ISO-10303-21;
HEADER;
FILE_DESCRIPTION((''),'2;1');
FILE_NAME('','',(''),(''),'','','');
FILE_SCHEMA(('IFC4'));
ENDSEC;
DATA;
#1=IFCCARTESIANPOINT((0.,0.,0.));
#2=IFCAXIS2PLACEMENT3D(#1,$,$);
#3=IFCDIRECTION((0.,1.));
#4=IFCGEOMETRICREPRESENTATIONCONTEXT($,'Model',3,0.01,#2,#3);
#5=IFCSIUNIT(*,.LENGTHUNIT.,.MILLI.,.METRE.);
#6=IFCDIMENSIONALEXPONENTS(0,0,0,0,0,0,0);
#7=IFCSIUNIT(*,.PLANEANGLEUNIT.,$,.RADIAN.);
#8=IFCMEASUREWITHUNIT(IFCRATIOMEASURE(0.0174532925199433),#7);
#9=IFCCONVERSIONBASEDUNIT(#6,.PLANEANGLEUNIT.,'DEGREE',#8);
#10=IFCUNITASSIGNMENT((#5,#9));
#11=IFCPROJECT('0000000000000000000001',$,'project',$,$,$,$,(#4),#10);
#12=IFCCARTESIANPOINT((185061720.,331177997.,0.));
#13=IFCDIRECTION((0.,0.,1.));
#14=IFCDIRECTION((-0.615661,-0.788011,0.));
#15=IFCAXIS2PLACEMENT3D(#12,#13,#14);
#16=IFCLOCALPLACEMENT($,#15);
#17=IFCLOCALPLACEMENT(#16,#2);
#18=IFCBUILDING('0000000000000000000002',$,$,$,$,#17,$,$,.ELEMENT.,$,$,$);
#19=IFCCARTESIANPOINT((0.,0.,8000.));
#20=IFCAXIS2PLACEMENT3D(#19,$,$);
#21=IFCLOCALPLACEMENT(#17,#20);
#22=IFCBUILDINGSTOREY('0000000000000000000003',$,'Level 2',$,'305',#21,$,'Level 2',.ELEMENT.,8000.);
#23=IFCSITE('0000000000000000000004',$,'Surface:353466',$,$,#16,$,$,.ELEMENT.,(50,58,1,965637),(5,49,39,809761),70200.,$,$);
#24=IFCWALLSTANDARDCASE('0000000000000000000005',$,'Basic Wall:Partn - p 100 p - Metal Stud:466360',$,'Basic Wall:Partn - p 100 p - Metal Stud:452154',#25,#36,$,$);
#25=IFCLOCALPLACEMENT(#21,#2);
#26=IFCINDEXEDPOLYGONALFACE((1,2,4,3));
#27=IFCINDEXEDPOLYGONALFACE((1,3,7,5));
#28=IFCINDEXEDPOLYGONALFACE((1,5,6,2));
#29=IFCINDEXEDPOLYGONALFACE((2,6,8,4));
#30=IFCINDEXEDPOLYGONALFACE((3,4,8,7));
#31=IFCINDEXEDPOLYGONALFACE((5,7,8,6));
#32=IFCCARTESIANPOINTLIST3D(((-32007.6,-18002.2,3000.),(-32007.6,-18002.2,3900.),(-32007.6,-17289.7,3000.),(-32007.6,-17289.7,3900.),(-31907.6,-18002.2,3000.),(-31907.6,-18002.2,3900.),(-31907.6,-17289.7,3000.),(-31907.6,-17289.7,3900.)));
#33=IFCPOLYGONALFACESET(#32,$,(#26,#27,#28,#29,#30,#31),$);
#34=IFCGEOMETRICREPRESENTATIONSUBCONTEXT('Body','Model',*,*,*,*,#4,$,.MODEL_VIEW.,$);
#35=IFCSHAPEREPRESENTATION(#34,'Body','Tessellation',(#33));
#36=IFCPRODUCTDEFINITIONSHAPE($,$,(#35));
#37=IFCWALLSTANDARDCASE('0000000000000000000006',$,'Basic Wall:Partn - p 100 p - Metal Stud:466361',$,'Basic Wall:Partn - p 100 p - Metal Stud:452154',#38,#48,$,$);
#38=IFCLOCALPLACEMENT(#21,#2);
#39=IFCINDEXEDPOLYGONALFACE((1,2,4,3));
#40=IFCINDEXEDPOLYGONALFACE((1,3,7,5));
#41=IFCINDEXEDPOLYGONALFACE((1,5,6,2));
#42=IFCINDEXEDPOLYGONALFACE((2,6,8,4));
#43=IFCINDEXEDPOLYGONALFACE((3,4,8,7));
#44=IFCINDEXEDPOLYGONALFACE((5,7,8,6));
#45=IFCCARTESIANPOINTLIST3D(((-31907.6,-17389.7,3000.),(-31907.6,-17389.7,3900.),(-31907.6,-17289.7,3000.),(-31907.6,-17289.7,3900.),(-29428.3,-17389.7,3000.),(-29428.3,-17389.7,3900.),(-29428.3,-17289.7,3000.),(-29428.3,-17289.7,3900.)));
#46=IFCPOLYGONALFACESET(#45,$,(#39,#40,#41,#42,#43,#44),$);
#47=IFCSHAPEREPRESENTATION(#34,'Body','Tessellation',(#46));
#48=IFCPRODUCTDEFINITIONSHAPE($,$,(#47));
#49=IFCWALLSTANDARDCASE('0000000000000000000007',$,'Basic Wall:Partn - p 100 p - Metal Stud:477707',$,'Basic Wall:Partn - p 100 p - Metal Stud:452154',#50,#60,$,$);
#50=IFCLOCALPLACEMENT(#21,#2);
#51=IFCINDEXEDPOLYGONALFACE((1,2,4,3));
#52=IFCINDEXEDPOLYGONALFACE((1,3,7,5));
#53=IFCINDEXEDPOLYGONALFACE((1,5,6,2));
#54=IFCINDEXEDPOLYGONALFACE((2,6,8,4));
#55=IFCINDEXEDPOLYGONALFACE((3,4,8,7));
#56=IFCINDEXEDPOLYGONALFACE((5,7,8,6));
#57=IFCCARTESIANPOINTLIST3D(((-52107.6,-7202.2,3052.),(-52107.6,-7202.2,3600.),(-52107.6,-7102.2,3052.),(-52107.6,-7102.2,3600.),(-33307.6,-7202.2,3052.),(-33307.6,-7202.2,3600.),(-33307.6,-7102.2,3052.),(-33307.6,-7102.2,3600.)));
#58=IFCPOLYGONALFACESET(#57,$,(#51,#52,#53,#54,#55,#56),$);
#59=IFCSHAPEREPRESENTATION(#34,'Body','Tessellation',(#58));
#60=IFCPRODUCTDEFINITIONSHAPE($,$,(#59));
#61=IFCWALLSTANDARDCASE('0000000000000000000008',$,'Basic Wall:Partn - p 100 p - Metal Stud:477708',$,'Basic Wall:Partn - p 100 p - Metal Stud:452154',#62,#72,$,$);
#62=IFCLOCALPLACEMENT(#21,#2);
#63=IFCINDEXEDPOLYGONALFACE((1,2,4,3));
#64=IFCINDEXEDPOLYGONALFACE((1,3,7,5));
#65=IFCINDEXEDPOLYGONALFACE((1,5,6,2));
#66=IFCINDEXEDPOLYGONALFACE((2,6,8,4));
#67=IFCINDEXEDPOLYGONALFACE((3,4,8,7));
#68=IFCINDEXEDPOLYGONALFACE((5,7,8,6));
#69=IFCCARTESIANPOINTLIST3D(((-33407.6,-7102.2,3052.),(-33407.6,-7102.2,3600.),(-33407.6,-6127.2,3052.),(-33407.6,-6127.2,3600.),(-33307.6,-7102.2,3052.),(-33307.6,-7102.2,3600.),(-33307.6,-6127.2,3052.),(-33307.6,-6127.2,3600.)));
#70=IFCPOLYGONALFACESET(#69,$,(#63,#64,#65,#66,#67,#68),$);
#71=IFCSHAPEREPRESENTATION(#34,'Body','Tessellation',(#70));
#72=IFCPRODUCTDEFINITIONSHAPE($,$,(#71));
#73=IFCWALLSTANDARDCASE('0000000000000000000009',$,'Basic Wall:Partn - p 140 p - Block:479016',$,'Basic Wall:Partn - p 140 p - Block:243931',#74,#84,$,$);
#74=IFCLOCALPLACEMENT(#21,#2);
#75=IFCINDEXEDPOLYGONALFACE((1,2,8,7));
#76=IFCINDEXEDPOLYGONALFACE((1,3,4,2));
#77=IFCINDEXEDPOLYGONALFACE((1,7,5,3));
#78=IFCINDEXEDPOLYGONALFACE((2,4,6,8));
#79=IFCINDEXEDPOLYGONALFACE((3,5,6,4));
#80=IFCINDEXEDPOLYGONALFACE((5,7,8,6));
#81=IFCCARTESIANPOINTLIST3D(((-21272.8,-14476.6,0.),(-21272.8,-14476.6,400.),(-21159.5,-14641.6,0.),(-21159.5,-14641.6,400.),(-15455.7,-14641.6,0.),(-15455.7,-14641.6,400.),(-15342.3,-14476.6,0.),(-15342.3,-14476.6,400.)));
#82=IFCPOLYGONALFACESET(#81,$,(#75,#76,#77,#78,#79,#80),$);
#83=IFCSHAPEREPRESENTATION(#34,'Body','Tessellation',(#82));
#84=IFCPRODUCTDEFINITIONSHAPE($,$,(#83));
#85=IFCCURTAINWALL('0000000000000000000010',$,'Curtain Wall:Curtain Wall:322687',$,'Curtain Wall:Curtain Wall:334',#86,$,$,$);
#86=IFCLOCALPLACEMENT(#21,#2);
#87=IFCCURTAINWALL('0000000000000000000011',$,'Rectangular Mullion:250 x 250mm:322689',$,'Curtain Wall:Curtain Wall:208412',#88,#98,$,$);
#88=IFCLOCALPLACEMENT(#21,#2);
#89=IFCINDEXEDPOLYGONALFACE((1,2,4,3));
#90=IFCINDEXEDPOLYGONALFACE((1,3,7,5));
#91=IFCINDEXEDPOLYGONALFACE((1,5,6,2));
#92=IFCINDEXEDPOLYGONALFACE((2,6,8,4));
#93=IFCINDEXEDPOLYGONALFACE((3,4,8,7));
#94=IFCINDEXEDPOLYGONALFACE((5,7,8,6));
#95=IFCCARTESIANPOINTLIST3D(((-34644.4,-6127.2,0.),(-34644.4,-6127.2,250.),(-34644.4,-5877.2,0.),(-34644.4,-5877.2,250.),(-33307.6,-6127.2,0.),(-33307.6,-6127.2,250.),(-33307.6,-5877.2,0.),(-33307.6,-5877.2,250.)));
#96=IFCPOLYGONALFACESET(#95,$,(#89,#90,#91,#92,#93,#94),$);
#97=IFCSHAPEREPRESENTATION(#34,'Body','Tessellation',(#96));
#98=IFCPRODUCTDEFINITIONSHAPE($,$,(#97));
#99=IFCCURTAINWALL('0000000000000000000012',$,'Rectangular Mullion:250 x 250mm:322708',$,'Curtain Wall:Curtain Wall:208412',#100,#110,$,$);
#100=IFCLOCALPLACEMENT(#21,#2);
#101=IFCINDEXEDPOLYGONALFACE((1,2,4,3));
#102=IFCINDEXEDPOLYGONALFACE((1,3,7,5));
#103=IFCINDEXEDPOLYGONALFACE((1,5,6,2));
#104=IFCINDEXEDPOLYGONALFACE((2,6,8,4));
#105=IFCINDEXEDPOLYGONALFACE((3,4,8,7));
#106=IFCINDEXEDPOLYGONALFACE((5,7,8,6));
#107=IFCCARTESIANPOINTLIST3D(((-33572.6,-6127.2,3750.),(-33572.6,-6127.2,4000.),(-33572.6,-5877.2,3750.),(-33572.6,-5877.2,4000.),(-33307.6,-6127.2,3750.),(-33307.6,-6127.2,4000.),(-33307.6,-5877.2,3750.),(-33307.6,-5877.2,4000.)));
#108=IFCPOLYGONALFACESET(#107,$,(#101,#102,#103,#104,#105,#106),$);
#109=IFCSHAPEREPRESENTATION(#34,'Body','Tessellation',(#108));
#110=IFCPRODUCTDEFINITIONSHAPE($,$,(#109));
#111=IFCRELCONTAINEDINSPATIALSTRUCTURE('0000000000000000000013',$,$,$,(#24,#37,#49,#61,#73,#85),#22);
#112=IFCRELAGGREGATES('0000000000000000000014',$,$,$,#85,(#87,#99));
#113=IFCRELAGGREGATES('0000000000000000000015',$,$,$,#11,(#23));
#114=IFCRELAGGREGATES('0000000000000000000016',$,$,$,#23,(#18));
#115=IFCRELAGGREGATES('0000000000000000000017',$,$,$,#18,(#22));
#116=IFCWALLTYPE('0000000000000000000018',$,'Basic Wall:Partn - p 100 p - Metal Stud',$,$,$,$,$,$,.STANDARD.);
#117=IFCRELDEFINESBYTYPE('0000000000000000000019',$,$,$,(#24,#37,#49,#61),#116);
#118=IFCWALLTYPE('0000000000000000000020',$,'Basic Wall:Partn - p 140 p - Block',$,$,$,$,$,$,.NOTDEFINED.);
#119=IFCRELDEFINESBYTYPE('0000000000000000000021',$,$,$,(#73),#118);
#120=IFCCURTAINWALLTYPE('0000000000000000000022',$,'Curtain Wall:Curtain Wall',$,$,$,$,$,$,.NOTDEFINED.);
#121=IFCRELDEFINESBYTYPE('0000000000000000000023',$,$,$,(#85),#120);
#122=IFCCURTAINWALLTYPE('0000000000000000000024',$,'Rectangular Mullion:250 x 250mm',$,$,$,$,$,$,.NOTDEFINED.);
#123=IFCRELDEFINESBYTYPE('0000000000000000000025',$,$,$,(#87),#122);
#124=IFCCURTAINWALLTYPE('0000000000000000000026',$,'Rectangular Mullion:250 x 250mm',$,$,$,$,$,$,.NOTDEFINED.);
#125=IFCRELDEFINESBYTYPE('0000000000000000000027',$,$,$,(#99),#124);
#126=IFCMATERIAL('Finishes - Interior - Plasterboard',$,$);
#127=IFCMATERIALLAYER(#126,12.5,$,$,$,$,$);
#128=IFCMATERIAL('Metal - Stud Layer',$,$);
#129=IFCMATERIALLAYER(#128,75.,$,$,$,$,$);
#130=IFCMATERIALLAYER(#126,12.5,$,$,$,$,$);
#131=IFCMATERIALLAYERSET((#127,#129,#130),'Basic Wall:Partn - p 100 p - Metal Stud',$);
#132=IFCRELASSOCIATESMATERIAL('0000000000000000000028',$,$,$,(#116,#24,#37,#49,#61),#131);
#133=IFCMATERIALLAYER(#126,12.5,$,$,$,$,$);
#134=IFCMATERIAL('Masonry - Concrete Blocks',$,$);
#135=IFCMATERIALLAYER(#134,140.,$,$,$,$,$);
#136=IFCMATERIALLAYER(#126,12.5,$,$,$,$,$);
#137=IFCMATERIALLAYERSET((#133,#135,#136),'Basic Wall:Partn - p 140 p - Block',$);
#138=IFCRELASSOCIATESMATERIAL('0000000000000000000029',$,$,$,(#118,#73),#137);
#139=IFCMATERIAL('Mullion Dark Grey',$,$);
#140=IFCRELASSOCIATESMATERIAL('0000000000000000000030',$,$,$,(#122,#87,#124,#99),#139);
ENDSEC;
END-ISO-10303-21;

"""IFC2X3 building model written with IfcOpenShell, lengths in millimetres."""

from ifc_helpers import new_model, entity, si_unit, converted_unit, direction, frame, frame_2d, origin, origin_2d_with_axis, place, context, subcontext, project, spatial, polyline, rectangle, outline, extrude, clip, halfspace, bounded_halfspace, source, transform, mapped, material, layer, layer_set, layer_usage, type_object, type_shapes, element, aggregate, save


model = new_model("IFC2X3")

# Units and contexts
model_context = context("Model", 3, precision=0.01, world=origin(), true_north=direction((0.0, 1.0)))
body_context = subcontext(model_context, "Body", "Model", "MODEL_VIEW")
ifc_project = project(units=[si_unit("LENGTHUNIT", "METRE", prefix="MILLI"), converted_unit("PLANEANGLEUNIT", "DEGREE", entity("IfcRatioMeasure", 0.0174532925199433), si_unit("PLANEANGLEUNIT", "RADIAN"), dimensions=[0, 0, 0, 0, 0, 0, 0])], contexts=[model_context])

# Site, building, storey
site_placement = place(None, frame((185061720.0, 331177997.0, 0.0), z_axis=(0.0, 0.0, 1.0), x_axis=(-0.615661, -0.788011, 0.0)))
site = spatial("IfcSite", under=ifc_project, at=site_placement, Name="Surface:353466", CompositionType="ELEMENT", RefLatitude=(50, 58, 1, 965637), RefLongitude=(5, 49, 39, 809761), RefElevation=70200.0)
building_placement = place(site_placement, origin())
building = spatial("IfcBuilding", under=site, at=building_placement, CompositionType="ELEMENT")
storey_placement = place(building_placement, frame((0.0, 0.0, 8000.0)))
storey = spatial("IfcBuildingStorey", under=building, at=storey_placement, Name="Level 2", ObjectType="305", LongName="Level 2", CompositionType="ELEMENT", Elevation=8000.0)

# Shared definitions
ifc_material_1 = material(Name="Masonry - Concrete Blocks")
ifc_material_2 = material(Name="Finishes - Interior - Plasterboard")

# Walls
ifc_layer_1 = layer(ifc_material_2, 12.5)
ifc_material_3 = material(Name="Metal - Stud Layer")
ifc_layer_2 = layer(ifc_material_3, 75.0)
ifc_layer_3 = layer(ifc_material_2, 12.5)
ifc_layer_set_1 = layer_set([ifc_layer_1, ifc_layer_2, ifc_layer_3], Name="Basic Wall:Partn - p 100 p - Metal Stud")
wall_type_1 = type_object("IfcWallType", Name="Basic Wall:Partn - p 100 p - Metal Stud", PredefinedType="STANDARD", material=ifc_layer_set_1)
ifc_layer_usage_1 = layer_usage(ifc_layer_set_1, "AXIS2", "NEGATIVE", 50.0)
wall_1_placement = place(storey_placement, frame((-31957.6, -17289.7, 3000.0), z_axis=(0.0, 0.0, 1.0), x_axis=(0.0, -1.0, 0.0)))
element("IfcWallStandardCase", 1, at=wall_1_placement, inside=storey, type_object=wall_type_1, material=ifc_layer_usage_1, Name="Basic Wall:Partn - p 100 p - Metal Stud:466360", ObjectType="Basic Wall:Partn - p 100 p - Metal Stud:452154", context=body_context, shape_type="SweptSolid", body=[
    extrude(rectangle(XDim=712.5, YDim=100.0, at=frame_2d((356.2, 0.0), x_axis=(-1.0, 0.0))), origin(), (0.0, 0.0, 1.0), 900.0),
])
ifc_layer_usage_2 = layer_usage(ifc_layer_set_1, "AXIS2", "NEGATIVE", 50.0)
wall_2_placement = place(storey_placement, frame((-29428.3, -17339.7, 3000.0), z_axis=(0.0, 0.0, 1.0), x_axis=(-1.0, 0.0, 0.0)))
element("IfcWallStandardCase", 2, at=wall_2_placement, inside=storey, type_object=wall_type_1, material=ifc_layer_usage_2, Name="Basic Wall:Partn - p 100 p - Metal Stud:466361", ObjectType="Basic Wall:Partn - p 100 p - Metal Stud:452154", context=body_context, shape_type="SweptSolid", body=[
    extrude(rectangle(XDim=2479.3, YDim=100.0, at=frame_2d((1239.6, 0.0), x_axis=(-1.0, 0.0))), origin(), (0.0, 0.0, 1.0), 900.0),
])
ifc_layer_usage_3 = layer_usage(ifc_layer_set_1, "AXIS2", "POSITIVE", -50.0)
wall_3_placement = place(storey_placement, frame((-33307.6, -7152.2, 3052.0), z_axis=(0.0, 0.0, 1.0), x_axis=(-1.0, 0.0, 0.0)))
element("IfcWallStandardCase", 3, at=wall_3_placement, inside=storey, type_object=wall_type_1, material=ifc_layer_usage_3, Name="Basic Wall:Partn - p 100 p - Metal Stud:477707", ObjectType="Basic Wall:Partn - p 100 p - Metal Stud:452154", context=body_context, shape_type="Clipping", body=[
    clip(extrude(rectangle(XDim=18800.0, YDim=100.0, at=frame_2d((9400.0, 0.0), x_axis=(-1.0, 0.0))), origin(), (0.0, 0.0, 1.0), 548.0), bounded_halfspace(frame((0.0, -50.0, 548.0), z_axis=(0.0, 0.0, -1.0), x_axis=(-1.0, 0.0, 0.0)), True, frame((0.0, -50.0, 548.0)), polyline([(0.0, 0.0), (100.0, 0.0), (18800.0, 0.0), (18800.0, 100.0), (0.0, 100.0), (0.0, 0.0)]))),
])
ifc_layer_usage_4 = layer_usage(ifc_layer_set_1, "AXIS2", "POSITIVE", -50.0)
wall_4_placement = place(storey_placement, frame((-33357.6, -6127.2, 3052.0), z_axis=(0.0, 0.0, 1.0), x_axis=(0.0, -1.0, 0.0)))
element("IfcWallStandardCase", 4, at=wall_4_placement, inside=storey, type_object=wall_type_1, material=ifc_layer_usage_4, Name="Basic Wall:Partn - p 100 p - Metal Stud:477708", ObjectType="Basic Wall:Partn - p 100 p - Metal Stud:452154", context=body_context, shape_type="SweptSolid", body=[
    extrude(rectangle(XDim=975.0, YDim=100.0, at=frame_2d((487.5, 0.0), x_axis=(-1.0, 0.0))), origin(), (0.0, 0.0, 1.0), 548.0),
])
ifc_layer_4 = layer(ifc_material_2, 12.5)
ifc_layer_5 = layer(ifc_material_1, 140.0)
ifc_layer_6 = layer(ifc_material_2, 12.5)
ifc_layer_set_2 = layer_set([ifc_layer_4, ifc_layer_5, ifc_layer_6], Name="Basic Wall:Partn - p 140 p - Block")
ifc_layer_usage_5 = layer_usage(ifc_layer_set_2, "AXIS2", "NEGATIVE", 82.5)
wall_type_2 = type_object("IfcWallType", Name="Basic Wall:Partn - p 140 p - Block", PredefinedType="NOTDEFINED", material=ifc_layer_set_2)
wall_5_placement = place(storey_placement, frame((-21272.8, -14559.1, 0.0)))
element("IfcWallStandardCase", 5, at=wall_5_placement, inside=storey, type_object=wall_type_2, material=ifc_layer_usage_5, Name="Basic Wall:Partn - p 140 p - Block:479016", ObjectType="Basic Wall:Partn - p 140 p - Block:243931", context=body_context, shape_type="Clipping", body=[
    clip(clip(extrude(outline(polyline([(5817.2, -82.5), (5930.5, 82.5), (5778.8, 82.5), (3047.7, 82.5), (2882.7, 82.5), (151.6, 82.5), (0.0, 82.5), (113.3, -82.5), (5817.2, -82.5)])), origin(), (0.0, 0.0, 1.0), 400.0), bounded_halfspace(frame((113.3, -82.5, 400.0)), False, frame((113.3, -82.5, 400.0)), polyline([(0.0, 0.0), (5703.8, 0.0), (5817.2, 165.0), (5665.5, 165.0), (2934.4, 165.0), (2769.4, 165.0), (38.3, 165.0), (-113.3, 165.0), (0.0, 0.0)]))), halfspace(frame((0.0, 0.0, -4000.0)), True)),
])

# Curtain walls
curtain_wall_type_1 = type_object("IfcCurtainWallType", Name="Curtain Wall:Curtain Wall", PredefinedType="NOTDEFINED")
curtain_wall_1_placement = place(storey_placement, frame((0.0, 0.0, -8000.0)))
curtain_wall_1 = element("IfcCurtainWall", 6, at=curtain_wall_1_placement, inside=storey, type_object=curtain_wall_type_1, Name="Curtain Wall:Curtain Wall:322687", ObjectType="Curtain Wall:Curtain Wall:334")
ifc_material_4 = material(Name="Mullion Dark Grey")
curtain_wall_type_2 = type_object("IfcCurtainWallType", Name="Rectangular Mullion:250 x 250mm", PredefinedType="NOTDEFINED", material=ifc_material_4)
shared_shape_1 = source(origin(), body_context, "Body", "SweptSolid", [
    extrude(rectangle(XDim=250.0, YDim=250.0, at=origin_2d_with_axis()), frame((-125.0, 0.0, -1336.8), z_axis=(0.0, 0.0, 1.0), x_axis=(-1.0, 0.0, 0.0)), (0.0, 0.0, 1.0), 1336.8),
])
type_shapes(curtain_wall_type_2, [shared_shape_1])
curtain_wall_2_placement = place(storey_placement, frame((-33307.6, -6002.2, 0.0), z_axis=(1.0, 0.0, 0.0), x_axis=(0.0, 0.0, -1.0)))
curtain_wall_2 = element("IfcCurtainWall", 7, at=curtain_wall_2_placement, type_object=curtain_wall_type_2, material=ifc_material_4, Name="Rectangular Mullion:250 x 250mm:322689", ObjectType="Curtain Wall:Curtain Wall:208412", context=body_context, shape_type="MappedRepresentation", body=[
    mapped(shared_shape_1, transform((0.0, 0.0, 0.0), scale=1.0)),
])
curtain_wall_type_3 = type_object("IfcCurtainWallType", Name="Rectangular Mullion:250 x 250mm", PredefinedType="NOTDEFINED", material=ifc_material_4)
shared_shape_2 = source(origin(), body_context, "Body", "SweptSolid", [
    extrude(rectangle(XDim=250.0, YDim=250.0, at=origin_2d_with_axis()), frame((-125.0, 0.0, -265.0), z_axis=(0.0, 0.0, 1.0), x_axis=(-1.0, 0.0, 0.0)), (0.0, 0.0, 1.0), 265.0),
])
type_shapes(curtain_wall_type_3, [shared_shape_2])
curtain_wall_3_placement = place(storey_placement, frame((-33572.6, -6002.2, 4000.0), z_axis=(-1.0, 0.0, 0.0), x_axis=(0.0, 0.0, 1.0)))
curtain_wall_3 = element("IfcCurtainWall", 8, at=curtain_wall_3_placement, type_object=curtain_wall_type_3, material=ifc_material_4, Name="Rectangular Mullion:250 x 250mm:322708", ObjectType="Curtain Wall:Curtain Wall:208412", context=body_context, shape_type="MappedRepresentation", body=[
    mapped(shared_shape_2, transform((0.0, 0.0, 0.0), scale=1.0)),
])
aggregate(curtain_wall_1, [curtain_wall_2, curtain_wall_3])

save(model, "model.ifc")
